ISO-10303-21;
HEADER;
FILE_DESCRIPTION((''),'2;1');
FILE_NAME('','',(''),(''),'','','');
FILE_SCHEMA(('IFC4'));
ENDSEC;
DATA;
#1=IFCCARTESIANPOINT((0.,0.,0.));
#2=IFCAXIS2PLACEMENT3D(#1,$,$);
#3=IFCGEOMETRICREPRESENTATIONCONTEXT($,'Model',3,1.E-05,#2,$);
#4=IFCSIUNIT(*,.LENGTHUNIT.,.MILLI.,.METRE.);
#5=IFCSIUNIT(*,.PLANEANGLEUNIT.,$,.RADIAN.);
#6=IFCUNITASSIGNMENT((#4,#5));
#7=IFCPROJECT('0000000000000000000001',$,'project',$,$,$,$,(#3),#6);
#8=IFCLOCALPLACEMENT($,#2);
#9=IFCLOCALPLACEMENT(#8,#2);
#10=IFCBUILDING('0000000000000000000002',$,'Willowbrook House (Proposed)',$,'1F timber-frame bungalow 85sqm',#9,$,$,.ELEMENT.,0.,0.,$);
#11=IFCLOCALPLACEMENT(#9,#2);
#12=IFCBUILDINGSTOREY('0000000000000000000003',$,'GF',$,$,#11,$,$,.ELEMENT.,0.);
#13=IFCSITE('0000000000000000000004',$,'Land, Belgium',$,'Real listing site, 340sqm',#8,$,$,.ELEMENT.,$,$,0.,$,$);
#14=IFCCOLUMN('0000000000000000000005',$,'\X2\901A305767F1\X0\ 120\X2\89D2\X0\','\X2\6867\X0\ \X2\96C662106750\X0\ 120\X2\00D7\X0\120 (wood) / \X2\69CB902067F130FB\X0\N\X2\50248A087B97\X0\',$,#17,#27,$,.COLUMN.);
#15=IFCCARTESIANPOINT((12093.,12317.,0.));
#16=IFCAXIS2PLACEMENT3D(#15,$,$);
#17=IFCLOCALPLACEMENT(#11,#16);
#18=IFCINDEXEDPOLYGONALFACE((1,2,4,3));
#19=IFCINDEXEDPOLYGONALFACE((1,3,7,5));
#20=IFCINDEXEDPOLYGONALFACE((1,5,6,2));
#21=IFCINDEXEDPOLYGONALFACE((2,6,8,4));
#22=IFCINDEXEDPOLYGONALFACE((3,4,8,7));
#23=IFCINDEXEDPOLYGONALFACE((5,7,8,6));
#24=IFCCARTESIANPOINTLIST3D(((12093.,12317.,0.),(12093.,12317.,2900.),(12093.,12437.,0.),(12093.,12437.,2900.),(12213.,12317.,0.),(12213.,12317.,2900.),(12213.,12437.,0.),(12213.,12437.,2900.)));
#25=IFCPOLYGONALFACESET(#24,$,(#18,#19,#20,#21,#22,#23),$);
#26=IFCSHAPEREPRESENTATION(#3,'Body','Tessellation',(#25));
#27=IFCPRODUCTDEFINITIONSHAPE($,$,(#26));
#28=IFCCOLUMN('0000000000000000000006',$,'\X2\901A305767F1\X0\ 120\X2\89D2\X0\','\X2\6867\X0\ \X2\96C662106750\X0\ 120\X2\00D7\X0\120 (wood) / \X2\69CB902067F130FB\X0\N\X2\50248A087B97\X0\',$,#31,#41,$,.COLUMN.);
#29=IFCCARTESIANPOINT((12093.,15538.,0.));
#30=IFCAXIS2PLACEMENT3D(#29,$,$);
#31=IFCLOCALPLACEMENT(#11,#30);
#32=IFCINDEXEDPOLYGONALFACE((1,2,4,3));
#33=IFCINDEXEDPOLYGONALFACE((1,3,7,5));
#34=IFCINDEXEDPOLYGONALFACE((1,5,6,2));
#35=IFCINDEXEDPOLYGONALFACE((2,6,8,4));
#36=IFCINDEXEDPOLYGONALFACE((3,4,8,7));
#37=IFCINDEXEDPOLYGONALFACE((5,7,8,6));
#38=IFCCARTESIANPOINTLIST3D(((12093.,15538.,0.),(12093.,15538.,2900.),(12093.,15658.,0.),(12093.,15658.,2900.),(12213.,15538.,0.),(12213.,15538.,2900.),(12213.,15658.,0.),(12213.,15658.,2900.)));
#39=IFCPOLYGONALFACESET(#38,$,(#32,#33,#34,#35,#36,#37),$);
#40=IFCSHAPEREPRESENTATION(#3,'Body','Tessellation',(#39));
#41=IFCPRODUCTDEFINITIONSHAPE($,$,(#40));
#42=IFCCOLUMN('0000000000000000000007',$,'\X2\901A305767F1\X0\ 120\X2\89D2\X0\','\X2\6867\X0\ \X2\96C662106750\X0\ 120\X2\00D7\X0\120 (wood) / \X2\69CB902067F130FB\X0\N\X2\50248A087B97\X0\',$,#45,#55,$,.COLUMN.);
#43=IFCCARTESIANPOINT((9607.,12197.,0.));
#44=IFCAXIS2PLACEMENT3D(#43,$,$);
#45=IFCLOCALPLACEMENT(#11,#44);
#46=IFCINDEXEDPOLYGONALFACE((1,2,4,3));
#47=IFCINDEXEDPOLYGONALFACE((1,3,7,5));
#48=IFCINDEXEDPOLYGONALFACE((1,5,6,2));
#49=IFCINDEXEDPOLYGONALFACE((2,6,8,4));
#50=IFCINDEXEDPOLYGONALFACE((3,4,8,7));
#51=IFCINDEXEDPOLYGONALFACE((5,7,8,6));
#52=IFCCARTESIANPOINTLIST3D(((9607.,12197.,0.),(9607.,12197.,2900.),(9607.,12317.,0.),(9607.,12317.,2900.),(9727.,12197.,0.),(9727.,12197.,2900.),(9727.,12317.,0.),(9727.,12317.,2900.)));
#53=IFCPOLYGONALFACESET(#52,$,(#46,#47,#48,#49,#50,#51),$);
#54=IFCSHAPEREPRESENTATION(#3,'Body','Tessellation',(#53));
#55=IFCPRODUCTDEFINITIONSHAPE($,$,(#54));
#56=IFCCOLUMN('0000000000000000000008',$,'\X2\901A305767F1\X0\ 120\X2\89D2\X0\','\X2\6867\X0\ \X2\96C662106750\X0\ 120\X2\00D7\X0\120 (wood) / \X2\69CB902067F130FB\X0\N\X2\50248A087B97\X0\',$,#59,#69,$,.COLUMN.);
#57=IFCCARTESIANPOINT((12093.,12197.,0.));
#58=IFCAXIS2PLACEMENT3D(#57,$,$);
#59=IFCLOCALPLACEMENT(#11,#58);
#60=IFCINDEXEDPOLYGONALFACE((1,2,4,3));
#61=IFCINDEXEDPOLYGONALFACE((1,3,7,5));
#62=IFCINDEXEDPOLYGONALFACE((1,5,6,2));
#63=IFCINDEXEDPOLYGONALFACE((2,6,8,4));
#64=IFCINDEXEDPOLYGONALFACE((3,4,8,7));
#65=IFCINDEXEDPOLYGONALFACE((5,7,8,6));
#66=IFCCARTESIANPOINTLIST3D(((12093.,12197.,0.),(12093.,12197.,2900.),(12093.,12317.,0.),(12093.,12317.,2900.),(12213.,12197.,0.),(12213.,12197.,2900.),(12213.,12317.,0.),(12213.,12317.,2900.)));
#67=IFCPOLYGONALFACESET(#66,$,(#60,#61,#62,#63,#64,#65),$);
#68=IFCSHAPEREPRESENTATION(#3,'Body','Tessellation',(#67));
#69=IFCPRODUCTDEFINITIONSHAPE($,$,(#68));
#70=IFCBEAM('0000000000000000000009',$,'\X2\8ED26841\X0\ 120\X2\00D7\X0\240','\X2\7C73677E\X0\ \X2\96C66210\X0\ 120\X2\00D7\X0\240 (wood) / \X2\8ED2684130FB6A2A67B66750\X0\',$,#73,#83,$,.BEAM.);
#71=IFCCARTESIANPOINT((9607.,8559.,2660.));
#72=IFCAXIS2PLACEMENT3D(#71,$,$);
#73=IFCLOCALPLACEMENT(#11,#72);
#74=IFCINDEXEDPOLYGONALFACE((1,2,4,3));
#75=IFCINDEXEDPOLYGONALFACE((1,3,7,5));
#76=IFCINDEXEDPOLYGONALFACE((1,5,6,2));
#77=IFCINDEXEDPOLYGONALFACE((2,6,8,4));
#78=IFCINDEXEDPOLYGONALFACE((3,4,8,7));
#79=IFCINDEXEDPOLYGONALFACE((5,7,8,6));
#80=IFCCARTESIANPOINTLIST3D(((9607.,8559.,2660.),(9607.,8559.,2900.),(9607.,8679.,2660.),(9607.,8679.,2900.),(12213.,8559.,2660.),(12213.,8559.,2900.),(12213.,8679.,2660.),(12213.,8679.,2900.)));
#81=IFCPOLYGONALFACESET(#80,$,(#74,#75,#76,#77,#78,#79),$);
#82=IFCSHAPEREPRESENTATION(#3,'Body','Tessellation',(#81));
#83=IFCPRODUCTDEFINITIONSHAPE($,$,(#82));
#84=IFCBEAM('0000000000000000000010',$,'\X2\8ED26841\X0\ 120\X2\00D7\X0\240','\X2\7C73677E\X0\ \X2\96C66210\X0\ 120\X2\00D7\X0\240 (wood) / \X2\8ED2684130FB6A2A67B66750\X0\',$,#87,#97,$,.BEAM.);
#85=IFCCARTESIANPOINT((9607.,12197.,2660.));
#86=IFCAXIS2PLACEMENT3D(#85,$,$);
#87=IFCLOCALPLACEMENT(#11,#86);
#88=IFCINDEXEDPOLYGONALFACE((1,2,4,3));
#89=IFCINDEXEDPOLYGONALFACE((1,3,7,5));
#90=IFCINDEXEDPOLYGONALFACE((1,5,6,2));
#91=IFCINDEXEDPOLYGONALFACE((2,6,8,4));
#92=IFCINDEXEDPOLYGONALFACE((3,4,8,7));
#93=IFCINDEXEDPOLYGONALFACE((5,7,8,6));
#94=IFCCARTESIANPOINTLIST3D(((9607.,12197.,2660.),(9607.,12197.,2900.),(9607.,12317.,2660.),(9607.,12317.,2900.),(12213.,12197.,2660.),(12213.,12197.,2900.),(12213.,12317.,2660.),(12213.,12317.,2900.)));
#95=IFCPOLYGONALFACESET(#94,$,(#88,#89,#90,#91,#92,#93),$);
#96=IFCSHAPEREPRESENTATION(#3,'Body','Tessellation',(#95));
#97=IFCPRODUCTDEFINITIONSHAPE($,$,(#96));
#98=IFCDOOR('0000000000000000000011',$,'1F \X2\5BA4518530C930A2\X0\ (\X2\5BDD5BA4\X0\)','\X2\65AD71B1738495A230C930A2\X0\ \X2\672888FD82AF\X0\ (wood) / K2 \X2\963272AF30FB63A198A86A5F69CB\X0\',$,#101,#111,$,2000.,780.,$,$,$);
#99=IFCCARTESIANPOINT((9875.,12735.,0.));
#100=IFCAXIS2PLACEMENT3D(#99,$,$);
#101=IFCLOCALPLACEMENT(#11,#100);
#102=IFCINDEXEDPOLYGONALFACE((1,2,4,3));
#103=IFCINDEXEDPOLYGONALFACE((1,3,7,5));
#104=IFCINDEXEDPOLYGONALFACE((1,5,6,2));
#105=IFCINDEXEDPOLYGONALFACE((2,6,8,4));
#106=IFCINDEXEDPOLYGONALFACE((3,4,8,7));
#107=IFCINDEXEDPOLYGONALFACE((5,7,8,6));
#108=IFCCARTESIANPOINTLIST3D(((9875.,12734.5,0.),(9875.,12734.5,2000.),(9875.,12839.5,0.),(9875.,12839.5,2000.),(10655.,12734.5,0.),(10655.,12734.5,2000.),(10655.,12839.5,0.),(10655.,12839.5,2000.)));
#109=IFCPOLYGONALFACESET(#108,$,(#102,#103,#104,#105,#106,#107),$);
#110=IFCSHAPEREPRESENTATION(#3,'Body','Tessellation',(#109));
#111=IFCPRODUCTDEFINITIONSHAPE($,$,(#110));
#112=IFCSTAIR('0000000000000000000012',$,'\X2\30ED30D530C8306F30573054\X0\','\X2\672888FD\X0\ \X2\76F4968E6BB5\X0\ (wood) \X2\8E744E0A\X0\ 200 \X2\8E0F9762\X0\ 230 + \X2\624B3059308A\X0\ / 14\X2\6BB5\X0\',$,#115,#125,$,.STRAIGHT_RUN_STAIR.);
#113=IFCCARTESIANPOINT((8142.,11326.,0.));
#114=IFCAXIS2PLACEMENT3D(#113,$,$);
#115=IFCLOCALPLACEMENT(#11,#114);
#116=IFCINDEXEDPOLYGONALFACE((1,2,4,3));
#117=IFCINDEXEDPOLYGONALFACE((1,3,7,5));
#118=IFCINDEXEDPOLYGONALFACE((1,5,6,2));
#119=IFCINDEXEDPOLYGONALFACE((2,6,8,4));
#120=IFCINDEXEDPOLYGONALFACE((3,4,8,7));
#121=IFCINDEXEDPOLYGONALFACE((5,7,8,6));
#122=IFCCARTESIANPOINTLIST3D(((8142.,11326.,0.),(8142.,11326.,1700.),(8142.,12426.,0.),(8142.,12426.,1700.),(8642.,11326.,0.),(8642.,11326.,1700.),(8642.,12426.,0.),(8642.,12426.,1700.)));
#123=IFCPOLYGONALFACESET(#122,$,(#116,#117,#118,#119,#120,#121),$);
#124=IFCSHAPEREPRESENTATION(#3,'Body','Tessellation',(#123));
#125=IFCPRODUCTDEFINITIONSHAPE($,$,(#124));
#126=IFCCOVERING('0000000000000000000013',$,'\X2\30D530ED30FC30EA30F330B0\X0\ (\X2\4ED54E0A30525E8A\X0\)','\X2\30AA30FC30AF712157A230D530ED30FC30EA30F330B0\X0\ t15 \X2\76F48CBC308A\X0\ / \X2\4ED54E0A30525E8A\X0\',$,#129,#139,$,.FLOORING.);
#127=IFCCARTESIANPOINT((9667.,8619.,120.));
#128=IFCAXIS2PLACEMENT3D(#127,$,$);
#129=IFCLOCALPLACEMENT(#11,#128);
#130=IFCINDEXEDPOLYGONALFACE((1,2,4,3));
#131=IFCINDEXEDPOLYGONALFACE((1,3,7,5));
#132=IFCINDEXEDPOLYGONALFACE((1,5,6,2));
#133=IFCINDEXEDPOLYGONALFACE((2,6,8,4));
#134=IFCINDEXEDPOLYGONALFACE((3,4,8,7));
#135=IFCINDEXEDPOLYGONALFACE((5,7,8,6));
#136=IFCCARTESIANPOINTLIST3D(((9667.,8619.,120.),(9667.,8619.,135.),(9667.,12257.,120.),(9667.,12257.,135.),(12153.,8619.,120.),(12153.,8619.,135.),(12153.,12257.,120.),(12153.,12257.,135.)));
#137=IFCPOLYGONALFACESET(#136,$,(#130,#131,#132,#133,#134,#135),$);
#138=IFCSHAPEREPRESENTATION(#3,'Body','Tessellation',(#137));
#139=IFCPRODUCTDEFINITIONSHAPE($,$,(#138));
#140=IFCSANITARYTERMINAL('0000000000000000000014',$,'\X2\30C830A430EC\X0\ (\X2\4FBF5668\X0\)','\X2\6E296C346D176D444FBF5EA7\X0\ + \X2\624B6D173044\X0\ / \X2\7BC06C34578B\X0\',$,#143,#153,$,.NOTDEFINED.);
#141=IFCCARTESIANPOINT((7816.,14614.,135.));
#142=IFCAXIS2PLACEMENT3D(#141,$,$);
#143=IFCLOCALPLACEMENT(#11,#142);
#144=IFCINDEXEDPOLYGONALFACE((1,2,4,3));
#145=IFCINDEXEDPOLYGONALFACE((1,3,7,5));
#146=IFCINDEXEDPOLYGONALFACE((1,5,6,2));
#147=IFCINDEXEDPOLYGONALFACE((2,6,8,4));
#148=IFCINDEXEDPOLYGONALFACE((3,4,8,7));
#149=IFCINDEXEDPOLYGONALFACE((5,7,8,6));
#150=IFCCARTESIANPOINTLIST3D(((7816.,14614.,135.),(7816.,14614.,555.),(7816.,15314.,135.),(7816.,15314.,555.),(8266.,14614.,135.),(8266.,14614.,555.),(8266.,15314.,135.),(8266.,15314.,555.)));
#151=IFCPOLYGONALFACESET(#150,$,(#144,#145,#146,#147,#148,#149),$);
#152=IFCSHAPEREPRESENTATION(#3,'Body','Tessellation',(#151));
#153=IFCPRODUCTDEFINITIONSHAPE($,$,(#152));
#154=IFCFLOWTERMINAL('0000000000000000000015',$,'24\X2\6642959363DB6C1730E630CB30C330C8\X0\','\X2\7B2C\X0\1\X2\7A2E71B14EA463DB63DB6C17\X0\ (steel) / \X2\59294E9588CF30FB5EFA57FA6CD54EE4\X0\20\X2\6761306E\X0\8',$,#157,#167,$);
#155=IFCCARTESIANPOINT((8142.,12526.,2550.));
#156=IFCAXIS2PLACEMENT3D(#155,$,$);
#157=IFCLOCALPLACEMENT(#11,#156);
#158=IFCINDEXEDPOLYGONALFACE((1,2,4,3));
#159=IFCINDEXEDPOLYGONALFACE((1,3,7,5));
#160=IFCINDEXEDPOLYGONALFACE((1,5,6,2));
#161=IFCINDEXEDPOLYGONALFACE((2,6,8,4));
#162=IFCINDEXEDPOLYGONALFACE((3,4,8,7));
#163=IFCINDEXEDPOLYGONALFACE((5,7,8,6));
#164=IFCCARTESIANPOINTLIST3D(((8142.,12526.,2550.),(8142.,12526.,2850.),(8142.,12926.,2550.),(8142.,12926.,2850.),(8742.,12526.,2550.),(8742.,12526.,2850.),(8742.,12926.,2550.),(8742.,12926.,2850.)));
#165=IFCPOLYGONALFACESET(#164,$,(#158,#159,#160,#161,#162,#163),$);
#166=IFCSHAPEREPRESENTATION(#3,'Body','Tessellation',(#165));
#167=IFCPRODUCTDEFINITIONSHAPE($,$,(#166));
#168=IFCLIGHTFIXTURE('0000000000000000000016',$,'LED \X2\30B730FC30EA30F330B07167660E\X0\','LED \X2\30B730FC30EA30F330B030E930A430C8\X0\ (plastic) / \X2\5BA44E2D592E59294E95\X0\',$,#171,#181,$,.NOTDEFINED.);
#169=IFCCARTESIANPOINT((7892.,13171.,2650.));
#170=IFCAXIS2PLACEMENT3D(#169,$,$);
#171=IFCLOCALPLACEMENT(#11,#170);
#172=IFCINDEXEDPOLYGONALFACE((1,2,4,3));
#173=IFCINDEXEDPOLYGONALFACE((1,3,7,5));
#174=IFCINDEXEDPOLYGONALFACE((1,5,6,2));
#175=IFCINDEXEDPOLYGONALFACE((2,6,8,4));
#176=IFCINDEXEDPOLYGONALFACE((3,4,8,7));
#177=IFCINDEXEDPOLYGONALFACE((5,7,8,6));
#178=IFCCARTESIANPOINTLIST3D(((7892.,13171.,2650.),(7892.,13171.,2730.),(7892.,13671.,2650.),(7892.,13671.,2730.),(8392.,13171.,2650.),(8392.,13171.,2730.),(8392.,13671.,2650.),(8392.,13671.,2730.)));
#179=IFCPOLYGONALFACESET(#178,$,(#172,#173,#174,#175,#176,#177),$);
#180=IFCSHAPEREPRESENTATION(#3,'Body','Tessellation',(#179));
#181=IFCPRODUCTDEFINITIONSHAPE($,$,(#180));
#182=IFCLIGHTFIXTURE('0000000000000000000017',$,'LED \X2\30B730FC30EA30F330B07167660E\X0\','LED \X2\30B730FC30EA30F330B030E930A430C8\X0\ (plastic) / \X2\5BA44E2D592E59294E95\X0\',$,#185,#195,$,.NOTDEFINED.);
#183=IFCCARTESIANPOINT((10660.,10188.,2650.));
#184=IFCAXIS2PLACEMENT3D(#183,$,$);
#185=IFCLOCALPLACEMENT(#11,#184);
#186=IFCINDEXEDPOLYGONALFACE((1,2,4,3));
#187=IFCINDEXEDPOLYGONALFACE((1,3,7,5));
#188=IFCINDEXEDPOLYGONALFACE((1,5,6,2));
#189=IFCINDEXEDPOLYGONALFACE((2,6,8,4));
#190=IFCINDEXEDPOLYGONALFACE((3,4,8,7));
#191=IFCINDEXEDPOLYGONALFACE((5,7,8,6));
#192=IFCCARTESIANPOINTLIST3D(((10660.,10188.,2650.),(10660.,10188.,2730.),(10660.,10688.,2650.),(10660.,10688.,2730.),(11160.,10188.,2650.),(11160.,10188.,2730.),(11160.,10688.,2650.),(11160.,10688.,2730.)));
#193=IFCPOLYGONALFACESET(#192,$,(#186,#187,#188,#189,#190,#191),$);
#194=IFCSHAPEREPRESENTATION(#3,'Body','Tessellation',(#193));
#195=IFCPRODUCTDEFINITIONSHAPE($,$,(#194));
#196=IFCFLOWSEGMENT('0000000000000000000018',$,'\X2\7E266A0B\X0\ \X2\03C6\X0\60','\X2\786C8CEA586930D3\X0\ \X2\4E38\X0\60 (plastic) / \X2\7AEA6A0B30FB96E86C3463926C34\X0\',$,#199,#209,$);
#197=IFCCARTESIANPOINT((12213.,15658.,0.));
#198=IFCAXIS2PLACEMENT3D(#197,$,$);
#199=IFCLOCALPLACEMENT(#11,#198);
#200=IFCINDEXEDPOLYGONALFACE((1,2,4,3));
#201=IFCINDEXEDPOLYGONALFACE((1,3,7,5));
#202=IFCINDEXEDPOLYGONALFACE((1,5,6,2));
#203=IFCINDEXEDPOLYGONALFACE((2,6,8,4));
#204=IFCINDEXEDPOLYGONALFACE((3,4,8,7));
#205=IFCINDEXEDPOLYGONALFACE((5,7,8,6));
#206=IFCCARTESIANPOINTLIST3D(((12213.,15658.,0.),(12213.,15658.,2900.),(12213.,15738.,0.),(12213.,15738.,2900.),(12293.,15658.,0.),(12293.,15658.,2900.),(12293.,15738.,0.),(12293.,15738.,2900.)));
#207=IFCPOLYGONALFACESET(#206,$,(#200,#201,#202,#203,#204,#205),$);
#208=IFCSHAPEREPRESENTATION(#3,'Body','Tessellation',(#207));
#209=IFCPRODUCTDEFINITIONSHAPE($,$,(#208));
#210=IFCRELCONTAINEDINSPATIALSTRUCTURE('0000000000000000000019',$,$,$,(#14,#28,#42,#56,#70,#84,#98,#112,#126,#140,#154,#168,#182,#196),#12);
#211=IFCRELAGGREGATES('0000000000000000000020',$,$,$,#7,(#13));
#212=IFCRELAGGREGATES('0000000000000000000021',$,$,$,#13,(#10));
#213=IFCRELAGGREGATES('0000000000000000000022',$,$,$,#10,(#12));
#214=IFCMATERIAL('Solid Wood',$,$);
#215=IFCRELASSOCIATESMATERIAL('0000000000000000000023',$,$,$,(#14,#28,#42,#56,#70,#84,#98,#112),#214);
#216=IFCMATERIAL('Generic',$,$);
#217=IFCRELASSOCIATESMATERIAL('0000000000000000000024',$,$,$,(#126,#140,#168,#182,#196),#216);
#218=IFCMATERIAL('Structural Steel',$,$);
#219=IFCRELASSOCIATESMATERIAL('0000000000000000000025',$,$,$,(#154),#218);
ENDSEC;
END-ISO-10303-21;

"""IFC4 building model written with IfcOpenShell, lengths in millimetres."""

from ifc_helpers import new_model, si_unit, frame, frame_2d, origin, place, context, project, spatial, rectangle, extrude, material, element, save


model = new_model("IFC4")

# Units and contexts
model_context = context("Model", 3, precision=1e-05, world=origin())
ifc_project = project(units=[si_unit("LENGTHUNIT", "METRE", prefix="MILLI"), si_unit("PLANEANGLEUNIT", "RADIAN")], contexts=[model_context])

# Site, building, storey
site_placement = place(None, origin())
site = spatial("IfcSite", under=ifc_project, at=site_placement, Name="Land, Belgium", ObjectType="Real listing site, 340sqm", CompositionType="ELEMENT", RefElevation=0.0)
building_placement = place(site_placement, origin())
building = spatial("IfcBuilding", under=site, at=building_placement, Name="Willowbrook House (Proposed)", ObjectType="1F timber-frame bungalow 85sqm", CompositionType="ELEMENT", ElevationOfRefHeight=0.0, ElevationOfTerrain=0.0)
storey_placement = place(building_placement, origin())
storey = spatial("IfcBuildingStorey", under=building, at=storey_placement, Name="GF", CompositionType="ELEMENT", Elevation=0.0)

# Columns
ifc_material_1 = material(Name="Solid Wood")
column_1_placement = place(storey_placement, frame((12093.0, 12317.0, 0.0)))
element("IfcColumn", 1, at=column_1_placement, inside=storey, material=ifc_material_1, Name="通し柱 120角", Description="桧 集成材 120×120 (wood) / 構造柱・N値計算", PredefinedType="COLUMN", context=model_context, shape_type="SweptSolid", body=[
    extrude(rectangle(XDim=120.0, YDim=120.0, at=frame_2d((60.0, 60.0))), frame((12093.0, 12317.0, 0.0)), (0.0, 0.0, 1.0), 2900.0),
])
column_2_placement = place(storey_placement, frame((12093.0, 15538.0, 0.0)))
element("IfcColumn", 2, at=column_2_placement, inside=storey, material=ifc_material_1, Name="通し柱 120角", Description="桧 集成材 120×120 (wood) / 構造柱・N値計算", PredefinedType="COLUMN", context=model_context, shape_type="SweptSolid", body=[
    extrude(rectangle(XDim=120.0, YDim=120.0, at=frame_2d((60.0, 60.0))), frame((12093.0, 15538.0, 0.0)), (0.0, 0.0, 1.0), 2900.0),
])
column_3_placement = place(storey_placement, frame((9607.0, 12197.0, 0.0)))
element("IfcColumn", 3, at=column_3_placement, inside=storey, material=ifc_material_1, Name="通し柱 120角", Description="桧 集成材 120×120 (wood) / 構造柱・N値計算", PredefinedType="COLUMN", context=model_context, shape_type="SweptSolid", body=[
    extrude(rectangle(XDim=120.0, YDim=120.0, at=frame_2d((60.0, 60.0))), frame((9607.0, 12197.0, 0.0)), (0.0, 0.0, 1.0), 2900.0),
])
column_4_placement = place(storey_placement, frame((12093.0, 12197.0, 0.0)))
element("IfcColumn", 4, at=column_4_placement, inside=storey, material=ifc_material_1, Name="通し柱 120角", Description="桧 集成材 120×120 (wood) / 構造柱・N値計算", PredefinedType="COLUMN", context=model_context, shape_type="SweptSolid", body=[
    extrude(rectangle(XDim=120.0, YDim=120.0, at=frame_2d((60.0, 60.0))), frame((12093.0, 12197.0, 0.0)), (0.0, 0.0, 1.0), 2900.0),
])

# Beams
beam_1_placement = place(storey_placement, frame((9607.0, 8559.0, 2660.0)))
element("IfcBeam", 5, at=beam_1_placement, inside=storey, material=ifc_material_1, Name="軒桁 120×240", Description="米松 集成 120×240 (wood) / 軒桁・横架材", PredefinedType="BEAM", context=model_context, shape_type="SweptSolid", body=[
    extrude(rectangle(XDim=2606.0, YDim=120.0, at=frame_2d((1303.0, 60.0))), frame((9607.0, 8559.0, 2660.0)), (0.0, 0.0, 1.0), 240.0),
])
beam_2_placement = place(storey_placement, frame((9607.0, 12197.0, 2660.0)))
element("IfcBeam", 6, at=beam_2_placement, inside=storey, material=ifc_material_1, Name="軒桁 120×240", Description="米松 集成 120×240 (wood) / 軒桁・横架材", PredefinedType="BEAM", context=model_context, shape_type="SweptSolid", body=[
    extrude(rectangle(XDim=2606.0, YDim=120.0, at=frame_2d((1303.0, 60.0))), frame((9607.0, 12197.0, 2660.0)), (0.0, 0.0, 1.0), 240.0),
])

# Door
door_placement = place(storey_placement, frame((9875.0, 12735.0, 0.0)))
element("IfcDoor", 7, at=door_placement, inside=storey, material=ifc_material_1, Name="1F 室内ドア (寝室)", Description="断熱玄関ドア 木製芯 (wood) / K2 防犯・採風機構", OverallHeight=2000.0, OverallWidth=780.0, context=model_context, shape_type="SweptSolid", body=[
    extrude(rectangle(XDim=780.0, YDim=105.0, at=frame_2d((390.0, 52.0))), frame((9875.0, 12735.0, 0.0)), (0.0, 0.0, 1.0), 2000.0),
])

# Stair
stair_placement = place(storey_placement, frame((8142.0, 11326.0, 0.0)))
element("IfcStair", 8, at=stair_placement, inside=storey, material=ifc_material_1, Name="ロフトはしご", Description="木製 直階段 (wood) 蹴上 200 踏面 230 + 手すり / 14段", PredefinedType="STRAIGHT_RUN_STAIR", context=model_context, shape_type="SweptSolid", body=[
    extrude(rectangle(XDim=500.0, YDim=1100.0, at=frame_2d((250.0, 550.0))), frame((8142.0, 11326.0, 0.0)), (0.0, 0.0, 1.0), 1700.0),
])

# Covering
ifc_material_2 = material(Name="Generic")
covering_placement = place(storey_placement, frame((9667.0, 8619.0, 120.0)))
element("IfcCovering", 9, at=covering_placement, inside=storey, material=ifc_material_2, Name="フローリング (仕上げ床)", Description="オーク無垢フローリング t15 直貼り / 仕上げ床", PredefinedType="FLOORING", context=model_context, shape_type="SweptSolid", body=[
    extrude(rectangle(XDim=2486.0, YDim=3638.0, at=frame_2d((1243.0, 1819.0))), frame((9667.0, 8619.0, 120.0)), (0.0, 0.0, 1.0), 15.0),
])

# Sanitary terminal
sanitary_terminal_placement = place(storey_placement, frame((7816.0, 14614.0, 135.0)))
element("IfcSanitaryTerminal", 10, at=sanitary_terminal_placement, inside=storey, material=ifc_material_2, Name="トイレ (便器)", Description="温水洗浄便座 + 手洗い / 節水型", PredefinedType="NOTDEFINED", context=model_context, shape_type="SweptSolid", body=[
    extrude(rectangle(XDim=450.0, YDim=700.0, at=frame_2d((225.0, 350.0))), frame((7816.0, 14614.0, 135.0)), (0.0, 0.0, 1.0), 420.0),
])

# Flow terminal
ifc_material_3 = material(Name="Structural Steel")
flow_terminal_placement = place(storey_placement, frame((8142.0, 12526.0, 2550.0)))
element("IfcFlowTerminal", 11, at=flow_terminal_placement, inside=storey, material=ifc_material_3, Name="24時間換気ユニット", Description="第1種熱交換換気 (steel) / 天井裏・建基法令20条の8", context=model_context, shape_type="SweptSolid", body=[
    extrude(rectangle(XDim=600.0, YDim=400.0, at=frame_2d((300.0, 200.0))), frame((8142.0, 12526.0, 2550.0)), (0.0, 0.0, 1.0), 300.0),
])

# Light fixtures
light_fixture_1_placement = place(storey_placement, frame((7892.0, 13171.0, 2650.0)))
element("IfcLightFixture", 12, at=light_fixture_1_placement, inside=storey, material=ifc_material_2, Name="LED シーリング照明", Description="LED シーリングライト (plastic) / 室中央天井", PredefinedType="NOTDEFINED", context=model_context, shape_type="SweptSolid", body=[
    extrude(rectangle(XDim=500.0, YDim=500.0, at=frame_2d((250.0, 250.0))), frame((7892.0, 13171.0, 2650.0)), (0.0, 0.0, 1.0), 80.0),
])
light_fixture_2_placement = place(storey_placement, frame((10660.0, 10188.0, 2650.0)))
element("IfcLightFixture", 13, at=light_fixture_2_placement, inside=storey, material=ifc_material_2, Name="LED シーリング照明", Description="LED シーリングライト (plastic) / 室中央天井", PredefinedType="NOTDEFINED", context=model_context, shape_type="SweptSolid", body=[
    extrude(rectangle(XDim=500.0, YDim=500.0, at=frame_2d((250.0, 250.0))), frame((10660.0, 10188.0, 2650.0)), (0.0, 0.0, 1.0), 80.0),
])

# Flow segment
flow_segment_placement = place(storey_placement, frame((12213.0, 15658.0, 0.0)))
element("IfcFlowSegment", 14, at=flow_segment_placement, inside=storey, material=ifc_material_2, Name="縦樋 φ60", Description="硬質塩ビ 丸60 (plastic) / 竪樋・雨水排水", context=model_context, shape_type="SweptSolid", body=[
    extrude(rectangle(XDim=80.0, YDim=80.0, at=frame_2d((40.0, 40.0))), frame((12213.0, 15658.0, 0.0)), (0.0, 0.0, 1.0), 2900.0),
])

save(model, "model.ifc")
